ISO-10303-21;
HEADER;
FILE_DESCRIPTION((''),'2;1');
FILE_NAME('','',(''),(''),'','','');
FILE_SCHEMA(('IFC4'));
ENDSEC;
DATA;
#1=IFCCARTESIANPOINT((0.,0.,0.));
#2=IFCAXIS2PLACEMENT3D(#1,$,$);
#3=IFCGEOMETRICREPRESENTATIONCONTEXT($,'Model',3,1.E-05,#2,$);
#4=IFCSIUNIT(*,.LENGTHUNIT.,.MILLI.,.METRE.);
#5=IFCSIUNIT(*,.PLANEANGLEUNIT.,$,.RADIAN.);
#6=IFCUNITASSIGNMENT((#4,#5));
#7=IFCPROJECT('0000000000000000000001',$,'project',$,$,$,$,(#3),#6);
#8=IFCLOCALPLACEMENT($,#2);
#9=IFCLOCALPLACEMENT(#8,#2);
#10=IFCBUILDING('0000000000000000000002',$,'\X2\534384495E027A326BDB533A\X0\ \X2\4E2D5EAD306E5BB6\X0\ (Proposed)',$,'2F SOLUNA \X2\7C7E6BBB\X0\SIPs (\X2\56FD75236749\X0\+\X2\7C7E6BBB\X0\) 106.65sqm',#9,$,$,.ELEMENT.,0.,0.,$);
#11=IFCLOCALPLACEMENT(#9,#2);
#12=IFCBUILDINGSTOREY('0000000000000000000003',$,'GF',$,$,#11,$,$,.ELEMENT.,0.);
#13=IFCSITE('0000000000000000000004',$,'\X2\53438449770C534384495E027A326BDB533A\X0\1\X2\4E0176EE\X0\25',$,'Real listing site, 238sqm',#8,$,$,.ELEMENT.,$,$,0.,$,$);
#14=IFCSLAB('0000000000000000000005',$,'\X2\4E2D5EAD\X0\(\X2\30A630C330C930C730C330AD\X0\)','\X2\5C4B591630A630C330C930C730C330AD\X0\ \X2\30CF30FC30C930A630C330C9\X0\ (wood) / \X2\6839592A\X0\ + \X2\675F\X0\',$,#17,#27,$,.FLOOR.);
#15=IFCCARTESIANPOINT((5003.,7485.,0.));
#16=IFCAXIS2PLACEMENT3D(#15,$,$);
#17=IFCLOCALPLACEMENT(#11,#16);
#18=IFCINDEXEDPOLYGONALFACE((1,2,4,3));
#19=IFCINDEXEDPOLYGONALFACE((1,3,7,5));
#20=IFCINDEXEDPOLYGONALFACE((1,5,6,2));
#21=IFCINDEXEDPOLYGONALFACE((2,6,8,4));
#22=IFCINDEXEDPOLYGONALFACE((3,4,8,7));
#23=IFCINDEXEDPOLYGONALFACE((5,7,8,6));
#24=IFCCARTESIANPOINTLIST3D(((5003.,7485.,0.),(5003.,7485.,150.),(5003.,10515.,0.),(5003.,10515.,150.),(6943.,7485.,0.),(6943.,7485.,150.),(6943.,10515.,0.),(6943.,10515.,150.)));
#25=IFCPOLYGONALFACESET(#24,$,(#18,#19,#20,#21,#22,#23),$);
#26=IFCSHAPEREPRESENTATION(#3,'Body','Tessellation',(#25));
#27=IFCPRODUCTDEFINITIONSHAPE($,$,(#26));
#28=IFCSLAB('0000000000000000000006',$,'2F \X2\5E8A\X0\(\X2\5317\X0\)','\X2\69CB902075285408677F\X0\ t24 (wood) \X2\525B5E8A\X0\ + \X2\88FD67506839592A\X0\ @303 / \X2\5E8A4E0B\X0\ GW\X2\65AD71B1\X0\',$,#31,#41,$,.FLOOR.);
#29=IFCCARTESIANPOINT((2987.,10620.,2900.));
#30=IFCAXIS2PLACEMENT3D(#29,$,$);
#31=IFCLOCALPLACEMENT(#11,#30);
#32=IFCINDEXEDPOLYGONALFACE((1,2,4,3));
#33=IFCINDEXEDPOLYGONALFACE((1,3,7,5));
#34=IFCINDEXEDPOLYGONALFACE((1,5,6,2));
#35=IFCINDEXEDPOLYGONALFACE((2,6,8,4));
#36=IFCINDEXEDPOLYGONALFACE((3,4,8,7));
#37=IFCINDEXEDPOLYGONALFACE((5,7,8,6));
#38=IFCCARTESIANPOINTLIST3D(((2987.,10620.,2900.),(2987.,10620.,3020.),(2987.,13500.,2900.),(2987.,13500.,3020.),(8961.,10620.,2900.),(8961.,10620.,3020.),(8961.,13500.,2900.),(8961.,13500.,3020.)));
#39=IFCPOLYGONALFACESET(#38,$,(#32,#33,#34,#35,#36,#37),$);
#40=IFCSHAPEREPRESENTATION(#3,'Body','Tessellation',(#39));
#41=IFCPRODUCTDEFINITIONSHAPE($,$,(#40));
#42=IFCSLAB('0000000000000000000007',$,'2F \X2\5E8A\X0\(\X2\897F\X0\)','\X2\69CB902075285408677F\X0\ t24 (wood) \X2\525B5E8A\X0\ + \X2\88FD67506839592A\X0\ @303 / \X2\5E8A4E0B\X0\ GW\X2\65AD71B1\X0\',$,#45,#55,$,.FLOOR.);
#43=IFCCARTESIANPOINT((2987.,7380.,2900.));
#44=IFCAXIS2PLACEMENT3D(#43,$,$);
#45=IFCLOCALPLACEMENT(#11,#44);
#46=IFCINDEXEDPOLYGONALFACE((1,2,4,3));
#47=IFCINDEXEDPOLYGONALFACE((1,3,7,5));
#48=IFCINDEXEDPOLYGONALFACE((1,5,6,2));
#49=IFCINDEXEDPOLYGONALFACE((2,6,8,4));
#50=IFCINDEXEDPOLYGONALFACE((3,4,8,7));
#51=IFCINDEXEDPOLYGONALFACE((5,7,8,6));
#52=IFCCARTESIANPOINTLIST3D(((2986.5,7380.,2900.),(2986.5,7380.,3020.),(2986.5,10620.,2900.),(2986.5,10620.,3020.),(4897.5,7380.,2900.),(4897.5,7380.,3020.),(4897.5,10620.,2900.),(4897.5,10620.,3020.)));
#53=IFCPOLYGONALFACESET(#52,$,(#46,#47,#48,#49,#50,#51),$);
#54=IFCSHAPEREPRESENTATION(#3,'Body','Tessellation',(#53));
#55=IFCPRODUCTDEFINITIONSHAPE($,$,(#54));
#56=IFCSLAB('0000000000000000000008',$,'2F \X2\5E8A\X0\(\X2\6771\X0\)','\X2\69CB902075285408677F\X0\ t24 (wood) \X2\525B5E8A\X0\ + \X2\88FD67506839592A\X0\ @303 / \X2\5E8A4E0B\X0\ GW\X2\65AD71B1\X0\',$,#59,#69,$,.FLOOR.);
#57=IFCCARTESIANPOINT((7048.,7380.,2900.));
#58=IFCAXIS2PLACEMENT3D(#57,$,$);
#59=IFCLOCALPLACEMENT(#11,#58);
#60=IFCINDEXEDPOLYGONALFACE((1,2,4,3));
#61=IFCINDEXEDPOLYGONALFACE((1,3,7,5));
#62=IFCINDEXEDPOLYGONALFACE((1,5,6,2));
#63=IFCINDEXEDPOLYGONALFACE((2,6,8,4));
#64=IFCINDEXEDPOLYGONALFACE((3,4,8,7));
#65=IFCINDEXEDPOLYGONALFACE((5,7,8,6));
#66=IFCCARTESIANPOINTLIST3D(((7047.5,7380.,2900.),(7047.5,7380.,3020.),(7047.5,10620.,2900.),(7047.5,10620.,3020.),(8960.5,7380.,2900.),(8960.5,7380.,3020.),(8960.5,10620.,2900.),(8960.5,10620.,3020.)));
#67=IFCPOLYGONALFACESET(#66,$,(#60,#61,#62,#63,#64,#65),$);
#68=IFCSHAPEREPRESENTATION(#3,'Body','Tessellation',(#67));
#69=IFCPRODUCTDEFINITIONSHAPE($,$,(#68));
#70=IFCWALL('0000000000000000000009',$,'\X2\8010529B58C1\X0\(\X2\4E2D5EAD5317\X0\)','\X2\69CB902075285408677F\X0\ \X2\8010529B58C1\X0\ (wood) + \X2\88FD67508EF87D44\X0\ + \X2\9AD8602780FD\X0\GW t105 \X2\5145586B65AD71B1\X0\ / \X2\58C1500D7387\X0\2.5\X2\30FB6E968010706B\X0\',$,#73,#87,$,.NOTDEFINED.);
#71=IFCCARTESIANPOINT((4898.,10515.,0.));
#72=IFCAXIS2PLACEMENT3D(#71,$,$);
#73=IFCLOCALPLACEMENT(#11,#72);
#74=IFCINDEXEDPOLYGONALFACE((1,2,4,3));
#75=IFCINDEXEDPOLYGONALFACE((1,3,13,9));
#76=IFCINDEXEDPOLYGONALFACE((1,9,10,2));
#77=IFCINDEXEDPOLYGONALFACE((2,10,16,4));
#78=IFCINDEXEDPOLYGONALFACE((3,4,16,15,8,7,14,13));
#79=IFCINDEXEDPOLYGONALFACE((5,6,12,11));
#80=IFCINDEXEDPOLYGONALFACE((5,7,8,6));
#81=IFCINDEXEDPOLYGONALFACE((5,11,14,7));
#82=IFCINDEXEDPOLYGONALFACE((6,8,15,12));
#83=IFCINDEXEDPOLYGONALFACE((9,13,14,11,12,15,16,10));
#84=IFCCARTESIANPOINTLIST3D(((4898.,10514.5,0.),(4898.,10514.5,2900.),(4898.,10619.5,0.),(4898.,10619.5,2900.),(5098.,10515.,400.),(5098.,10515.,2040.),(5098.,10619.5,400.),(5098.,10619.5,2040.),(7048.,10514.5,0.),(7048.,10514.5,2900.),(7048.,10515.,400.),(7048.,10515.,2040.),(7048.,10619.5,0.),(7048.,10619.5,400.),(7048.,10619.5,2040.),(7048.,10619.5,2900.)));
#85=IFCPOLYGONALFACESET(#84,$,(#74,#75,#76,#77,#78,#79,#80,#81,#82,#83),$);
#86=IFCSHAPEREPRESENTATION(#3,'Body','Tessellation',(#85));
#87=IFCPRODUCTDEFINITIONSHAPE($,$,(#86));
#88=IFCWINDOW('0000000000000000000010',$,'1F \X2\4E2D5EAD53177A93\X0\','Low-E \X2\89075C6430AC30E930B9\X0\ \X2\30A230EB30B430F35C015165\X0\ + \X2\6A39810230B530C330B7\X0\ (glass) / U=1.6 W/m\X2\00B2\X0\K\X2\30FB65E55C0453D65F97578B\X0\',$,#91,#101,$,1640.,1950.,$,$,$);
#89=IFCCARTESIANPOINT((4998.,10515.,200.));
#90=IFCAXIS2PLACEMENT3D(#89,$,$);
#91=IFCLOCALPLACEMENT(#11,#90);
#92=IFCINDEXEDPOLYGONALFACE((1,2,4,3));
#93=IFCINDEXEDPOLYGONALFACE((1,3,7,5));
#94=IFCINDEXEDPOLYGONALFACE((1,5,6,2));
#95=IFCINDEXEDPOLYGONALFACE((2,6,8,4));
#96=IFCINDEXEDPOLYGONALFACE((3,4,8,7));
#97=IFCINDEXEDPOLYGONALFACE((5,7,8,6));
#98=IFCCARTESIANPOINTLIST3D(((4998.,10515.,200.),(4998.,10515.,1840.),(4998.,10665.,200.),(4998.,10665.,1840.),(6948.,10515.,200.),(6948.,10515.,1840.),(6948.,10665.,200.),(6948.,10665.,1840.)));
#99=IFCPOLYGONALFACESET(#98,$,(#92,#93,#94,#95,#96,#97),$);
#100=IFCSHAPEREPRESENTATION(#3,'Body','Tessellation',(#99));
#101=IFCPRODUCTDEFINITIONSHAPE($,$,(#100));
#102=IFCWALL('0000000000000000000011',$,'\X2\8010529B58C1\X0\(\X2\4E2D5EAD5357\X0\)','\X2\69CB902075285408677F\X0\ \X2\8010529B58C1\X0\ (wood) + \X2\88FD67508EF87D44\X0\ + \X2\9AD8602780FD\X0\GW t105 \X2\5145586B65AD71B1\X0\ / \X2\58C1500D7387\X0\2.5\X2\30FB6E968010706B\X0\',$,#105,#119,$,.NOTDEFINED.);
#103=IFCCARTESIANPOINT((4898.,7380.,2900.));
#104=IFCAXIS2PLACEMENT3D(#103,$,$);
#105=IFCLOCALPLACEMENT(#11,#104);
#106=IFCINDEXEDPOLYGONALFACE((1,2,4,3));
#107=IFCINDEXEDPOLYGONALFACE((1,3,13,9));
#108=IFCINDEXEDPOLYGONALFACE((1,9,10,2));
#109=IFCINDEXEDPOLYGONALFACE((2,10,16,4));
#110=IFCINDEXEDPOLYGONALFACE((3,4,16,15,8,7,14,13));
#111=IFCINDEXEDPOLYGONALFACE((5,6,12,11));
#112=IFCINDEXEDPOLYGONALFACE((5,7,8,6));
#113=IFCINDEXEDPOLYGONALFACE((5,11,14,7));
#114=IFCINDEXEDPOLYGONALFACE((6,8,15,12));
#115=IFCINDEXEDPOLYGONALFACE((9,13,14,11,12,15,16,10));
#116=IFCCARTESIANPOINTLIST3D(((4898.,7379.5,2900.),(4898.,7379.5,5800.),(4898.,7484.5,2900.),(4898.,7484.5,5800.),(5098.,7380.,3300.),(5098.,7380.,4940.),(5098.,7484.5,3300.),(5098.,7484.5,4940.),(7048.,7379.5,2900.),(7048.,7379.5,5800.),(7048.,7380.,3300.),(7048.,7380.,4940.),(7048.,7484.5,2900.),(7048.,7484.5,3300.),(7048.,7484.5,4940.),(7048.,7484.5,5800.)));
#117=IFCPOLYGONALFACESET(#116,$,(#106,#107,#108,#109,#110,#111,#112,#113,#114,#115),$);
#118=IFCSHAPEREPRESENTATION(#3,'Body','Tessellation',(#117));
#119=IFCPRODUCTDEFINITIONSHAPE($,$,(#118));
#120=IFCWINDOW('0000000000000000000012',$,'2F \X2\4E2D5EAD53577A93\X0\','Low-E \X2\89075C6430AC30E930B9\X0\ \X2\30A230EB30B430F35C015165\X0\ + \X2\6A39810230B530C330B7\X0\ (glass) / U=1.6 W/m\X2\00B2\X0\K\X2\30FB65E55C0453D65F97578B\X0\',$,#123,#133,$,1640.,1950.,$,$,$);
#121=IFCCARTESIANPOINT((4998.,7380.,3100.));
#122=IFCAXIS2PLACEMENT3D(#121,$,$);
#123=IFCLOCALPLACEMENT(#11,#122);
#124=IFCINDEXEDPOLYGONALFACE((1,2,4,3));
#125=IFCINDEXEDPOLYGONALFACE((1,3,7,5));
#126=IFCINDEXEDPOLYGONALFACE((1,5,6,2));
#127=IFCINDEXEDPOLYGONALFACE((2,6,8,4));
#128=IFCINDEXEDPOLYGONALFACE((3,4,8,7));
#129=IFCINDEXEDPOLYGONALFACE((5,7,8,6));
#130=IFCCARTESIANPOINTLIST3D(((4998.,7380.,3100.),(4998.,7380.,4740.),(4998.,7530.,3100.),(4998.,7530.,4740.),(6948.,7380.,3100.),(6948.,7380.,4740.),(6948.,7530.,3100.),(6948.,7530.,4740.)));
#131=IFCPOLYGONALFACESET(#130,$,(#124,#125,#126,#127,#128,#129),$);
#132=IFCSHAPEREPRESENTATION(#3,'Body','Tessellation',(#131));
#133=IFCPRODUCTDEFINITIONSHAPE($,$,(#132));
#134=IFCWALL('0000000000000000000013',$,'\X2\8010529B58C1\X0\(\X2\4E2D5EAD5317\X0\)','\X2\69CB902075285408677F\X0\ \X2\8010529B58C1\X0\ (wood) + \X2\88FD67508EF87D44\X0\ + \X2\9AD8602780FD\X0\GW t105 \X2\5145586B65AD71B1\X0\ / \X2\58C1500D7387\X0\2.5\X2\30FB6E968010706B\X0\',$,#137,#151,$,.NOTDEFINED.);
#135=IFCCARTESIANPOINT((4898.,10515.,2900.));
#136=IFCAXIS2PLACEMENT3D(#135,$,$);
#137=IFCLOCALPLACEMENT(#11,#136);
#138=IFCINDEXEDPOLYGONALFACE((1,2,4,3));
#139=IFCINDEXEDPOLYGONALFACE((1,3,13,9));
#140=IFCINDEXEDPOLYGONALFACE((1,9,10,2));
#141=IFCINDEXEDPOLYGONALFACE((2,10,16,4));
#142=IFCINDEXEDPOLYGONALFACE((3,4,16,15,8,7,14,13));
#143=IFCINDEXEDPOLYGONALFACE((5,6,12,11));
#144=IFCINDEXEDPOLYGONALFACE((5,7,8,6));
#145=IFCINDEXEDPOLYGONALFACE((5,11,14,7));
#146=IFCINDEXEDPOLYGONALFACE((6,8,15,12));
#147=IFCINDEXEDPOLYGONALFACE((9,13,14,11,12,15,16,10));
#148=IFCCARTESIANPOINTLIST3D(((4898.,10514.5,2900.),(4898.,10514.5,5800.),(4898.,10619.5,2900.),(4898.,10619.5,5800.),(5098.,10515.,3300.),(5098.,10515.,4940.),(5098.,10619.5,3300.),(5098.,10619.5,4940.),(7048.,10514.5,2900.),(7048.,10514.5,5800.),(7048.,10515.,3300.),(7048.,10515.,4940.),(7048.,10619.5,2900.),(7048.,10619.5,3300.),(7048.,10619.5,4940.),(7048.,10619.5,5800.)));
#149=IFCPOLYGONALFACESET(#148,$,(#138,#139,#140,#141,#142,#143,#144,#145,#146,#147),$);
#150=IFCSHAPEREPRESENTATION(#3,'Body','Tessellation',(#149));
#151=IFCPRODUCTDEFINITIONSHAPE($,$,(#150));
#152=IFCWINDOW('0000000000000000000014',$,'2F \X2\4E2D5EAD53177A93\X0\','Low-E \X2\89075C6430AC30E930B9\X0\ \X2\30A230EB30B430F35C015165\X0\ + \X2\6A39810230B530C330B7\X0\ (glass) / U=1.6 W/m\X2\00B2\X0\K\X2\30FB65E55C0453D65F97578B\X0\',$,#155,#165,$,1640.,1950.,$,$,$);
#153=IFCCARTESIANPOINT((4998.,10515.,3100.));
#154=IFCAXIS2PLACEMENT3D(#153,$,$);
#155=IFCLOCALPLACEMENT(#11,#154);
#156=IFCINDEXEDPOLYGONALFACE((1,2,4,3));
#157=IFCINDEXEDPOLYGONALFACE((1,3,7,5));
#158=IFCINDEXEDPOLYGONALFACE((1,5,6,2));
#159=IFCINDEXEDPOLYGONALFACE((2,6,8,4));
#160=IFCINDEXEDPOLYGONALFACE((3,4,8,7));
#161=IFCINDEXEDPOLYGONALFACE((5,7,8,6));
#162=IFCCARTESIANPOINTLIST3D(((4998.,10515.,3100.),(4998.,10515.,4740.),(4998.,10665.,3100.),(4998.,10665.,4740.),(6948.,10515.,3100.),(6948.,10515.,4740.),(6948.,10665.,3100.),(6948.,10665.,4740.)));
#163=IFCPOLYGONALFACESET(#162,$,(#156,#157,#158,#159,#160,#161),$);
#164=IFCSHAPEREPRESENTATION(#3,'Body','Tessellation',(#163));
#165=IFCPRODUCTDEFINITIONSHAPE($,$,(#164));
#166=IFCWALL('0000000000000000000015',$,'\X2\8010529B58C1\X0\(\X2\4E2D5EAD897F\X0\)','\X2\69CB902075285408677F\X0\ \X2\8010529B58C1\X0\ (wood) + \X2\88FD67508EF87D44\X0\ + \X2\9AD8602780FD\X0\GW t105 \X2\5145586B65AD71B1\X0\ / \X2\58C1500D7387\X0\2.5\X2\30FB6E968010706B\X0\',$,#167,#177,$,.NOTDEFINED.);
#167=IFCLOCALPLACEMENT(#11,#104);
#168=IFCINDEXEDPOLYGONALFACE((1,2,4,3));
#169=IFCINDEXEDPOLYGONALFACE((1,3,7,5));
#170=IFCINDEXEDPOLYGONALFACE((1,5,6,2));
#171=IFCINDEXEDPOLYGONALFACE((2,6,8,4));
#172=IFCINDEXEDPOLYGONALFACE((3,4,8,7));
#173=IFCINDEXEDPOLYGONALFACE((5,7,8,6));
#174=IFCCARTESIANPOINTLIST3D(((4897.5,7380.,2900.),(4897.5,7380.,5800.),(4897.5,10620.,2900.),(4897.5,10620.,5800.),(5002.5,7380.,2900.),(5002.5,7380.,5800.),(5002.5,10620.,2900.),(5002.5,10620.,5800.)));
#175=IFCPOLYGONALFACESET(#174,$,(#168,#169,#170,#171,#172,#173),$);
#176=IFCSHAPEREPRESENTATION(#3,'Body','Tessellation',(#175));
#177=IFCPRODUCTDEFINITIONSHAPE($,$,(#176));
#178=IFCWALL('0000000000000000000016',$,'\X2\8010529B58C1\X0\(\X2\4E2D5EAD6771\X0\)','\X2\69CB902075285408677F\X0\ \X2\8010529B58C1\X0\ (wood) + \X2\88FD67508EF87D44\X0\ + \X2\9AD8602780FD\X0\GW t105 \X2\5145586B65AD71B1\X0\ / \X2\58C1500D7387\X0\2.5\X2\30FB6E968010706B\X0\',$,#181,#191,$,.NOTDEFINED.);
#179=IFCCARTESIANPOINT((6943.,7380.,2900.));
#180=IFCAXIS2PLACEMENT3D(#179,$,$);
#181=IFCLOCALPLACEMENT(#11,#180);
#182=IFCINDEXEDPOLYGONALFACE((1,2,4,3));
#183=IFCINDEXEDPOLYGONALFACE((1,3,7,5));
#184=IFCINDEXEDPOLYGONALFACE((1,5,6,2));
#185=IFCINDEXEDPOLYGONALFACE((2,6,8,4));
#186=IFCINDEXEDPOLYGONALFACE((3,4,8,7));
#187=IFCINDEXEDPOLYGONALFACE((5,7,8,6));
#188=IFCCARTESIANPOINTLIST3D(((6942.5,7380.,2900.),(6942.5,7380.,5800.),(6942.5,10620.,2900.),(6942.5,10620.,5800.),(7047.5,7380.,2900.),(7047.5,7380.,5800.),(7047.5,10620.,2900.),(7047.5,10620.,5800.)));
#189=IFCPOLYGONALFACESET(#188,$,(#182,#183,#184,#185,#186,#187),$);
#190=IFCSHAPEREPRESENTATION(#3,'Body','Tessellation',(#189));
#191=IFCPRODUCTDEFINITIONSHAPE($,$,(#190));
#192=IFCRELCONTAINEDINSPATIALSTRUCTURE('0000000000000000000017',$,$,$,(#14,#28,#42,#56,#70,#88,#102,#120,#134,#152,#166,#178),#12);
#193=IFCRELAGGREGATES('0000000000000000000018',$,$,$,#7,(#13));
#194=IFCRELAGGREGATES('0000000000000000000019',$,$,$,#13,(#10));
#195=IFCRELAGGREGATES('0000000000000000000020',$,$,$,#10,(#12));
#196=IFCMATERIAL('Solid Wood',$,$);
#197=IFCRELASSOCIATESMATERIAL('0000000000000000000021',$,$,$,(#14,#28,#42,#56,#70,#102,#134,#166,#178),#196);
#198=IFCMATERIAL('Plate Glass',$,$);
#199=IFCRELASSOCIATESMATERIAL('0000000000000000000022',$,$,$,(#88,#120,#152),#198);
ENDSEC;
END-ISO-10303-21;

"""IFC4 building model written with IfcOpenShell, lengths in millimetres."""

from ifc_helpers import new_model, si_unit, frame, frame_2d, origin, place, context, project, spatial, rectangle, extrude, material, element, fill, save


model = new_model("IFC4")

# Units and contexts
model_context = context("Model", 3, precision=1e-05, world=origin())
ifc_project = project(units=[si_unit("LENGTHUNIT", "METRE", prefix="MILLI"), si_unit("PLANEANGLEUNIT", "RADIAN")], contexts=[model_context])

# Site, building, storey
site_placement = place(None, origin())
site = spatial("IfcSite", under=ifc_project, at=site_placement, Name="千葉県千葉市稲毛区1丁目25", ObjectType="Real listing site, 238sqm", CompositionType="ELEMENT", RefElevation=0.0)
building_placement = place(site_placement, origin())
building = spatial("IfcBuilding", under=site, at=building_placement, Name="千葉市稲毛区 中庭の家 (Proposed)", ObjectType="2F SOLUNA 籾殻SIPs (国産杉+籾殻) 106.65sqm", CompositionType="ELEMENT", ElevationOfRefHeight=0.0, ElevationOfTerrain=0.0)
storey_placement = place(building_placement, origin())
storey = spatial("IfcBuildingStorey", under=building, at=storey_placement, Name="GF", CompositionType="ELEMENT", Elevation=0.0)

# Slabs
ifc_material_1 = material(Name="Solid Wood")
slab_1_placement = place(storey_placement, frame((5003.0, 7485.0, 0.0)))
element("IfcSlab", 1, at=slab_1_placement, inside=storey, material=ifc_material_1, Name="中庭(ウッドデッキ)", Description="屋外ウッドデッキ ハードウッド (wood) / 根太 + 束", PredefinedType="FLOOR", context=model_context, shape_type="SweptSolid", body=[
    extrude(rectangle(XDim=1940.0, YDim=3030.0, at=frame_2d((970.0, 1515.0))), frame((5003.0, 7485.0, 0.0)), (0.0, 0.0, 1.0), 150.0),
])
slab_2_placement = place(storey_placement, frame((2987.0, 10620.0, 2900.0)))
element("IfcSlab", 2, at=slab_2_placement, inside=storey, material=ifc_material_1, Name="2F 床(北)", Description="構造用合板 t24 (wood) 剛床 + 製材根太 @303 / 床下 GW断熱", PredefinedType="FLOOR", context=model_context, shape_type="SweptSolid", body=[
    extrude(rectangle(XDim=5974.0, YDim=2880.0, at=frame_2d((2987.0, 1440.0))), frame((2987.0, 10620.0, 2900.0)), (0.0, 0.0, 1.0), 120.0),
])
slab_3_placement = place(storey_placement, frame((2987.0, 7380.0, 2900.0)))
element("IfcSlab", 3, at=slab_3_placement, inside=storey, material=ifc_material_1, Name="2F 床(西)", Description="構造用合板 t24 (wood) 剛床 + 製材根太 @303 / 床下 GW断熱", PredefinedType="FLOOR", context=model_context, shape_type="SweptSolid", body=[
    extrude(rectangle(XDim=1911.0, YDim=3240.0, at=frame_2d((955.0, 1620.0))), frame((2987.0, 7380.0, 2900.0)), (0.0, 0.0, 1.0), 120.0),
])
slab_4_placement = place(storey_placement, frame((7048.0, 7380.0, 2900.0)))
element("IfcSlab", 4, at=slab_4_placement, inside=storey, material=ifc_material_1, Name="2F 床(東)", Description="構造用合板 t24 (wood) 剛床 + 製材根太 @303 / 床下 GW断熱", PredefinedType="FLOOR", context=model_context, shape_type="SweptSolid", body=[
    extrude(rectangle(XDim=1913.0, YDim=3240.0, at=frame_2d((956.0, 1620.0))), frame((7048.0, 7380.0, 2900.0)), (0.0, 0.0, 1.0), 120.0),
])

# Wall, opening, window
wall_1_placement = place(storey_placement, frame((4898.0, 10515.0, 0.0)))
wall_1 = element("IfcWall", 5, at=wall_1_placement, inside=storey, material=ifc_material_1, Name="耐力壁(中庭北)", Description="構造用合板 耐力壁 (wood) + 製材軸組 + 高性能GW t105 充填断熱 / 壁倍率2.5・準耐火", PredefinedType="NOTDEFINED", context=model_context, shape_type="SweptSolid", body=[
    extrude(rectangle(XDim=2150.0, YDim=105.0, at=frame_2d((1075.0, 52.0))), frame((4898.0, 10515.0, 0.0)), (0.0, 0.0, 1.0), 2900.0),
])
opening_1_placement = place(storey_placement, frame((4998.0, 10515.0, 200.0)))
opening_1 = element("IfcOpeningElement", 6, at=opening_1_placement, cuts=wall_1, PredefinedType="NOTDEFINED", context=model_context, shape_type="SweptSolid", body=[
    extrude(rectangle(XDim=1950.0, YDim=150.0, at=frame_2d((975.0, 75.0))), frame((4998.0, 10515.0, 200.0)), (0.0, 0.0, 1.0), 1640.0),
])
ifc_material_2 = material(Name="Plate Glass")
window_1_placement = place(storey_placement, frame((4998.0, 10515.0, 200.0)))
window_1 = element("IfcWindow", 7, at=window_1_placement, inside=storey, material=ifc_material_2, Name="1F 中庭北窓", Description="Low-E 複層ガラス アルゴン封入 + 樹脂サッシ (glass) / U=1.6 W/m²K・日射取得型", OverallHeight=1640.0, OverallWidth=1950.0, context=model_context, shape_type="SweptSolid", body=[
    extrude(rectangle(XDim=1950.0, YDim=150.0, at=frame_2d((975.0, 75.0))), frame((4998.0, 10515.0, 200.0)), (0.0, 0.0, 1.0), 1640.0),
])
fill(opening_1, window_1)

# Walls, openings, windows
wall_2_placement = place(storey_placement, frame((4898.0, 7380.0, 2900.0)))
wall_2 = element("IfcWall", 8, at=wall_2_placement, inside=storey, material=ifc_material_1, Name="耐力壁(中庭南)", Description="構造用合板 耐力壁 (wood) + 製材軸組 + 高性能GW t105 充填断熱 / 壁倍率2.5・準耐火", PredefinedType="NOTDEFINED", context=model_context, shape_type="SweptSolid", body=[
    extrude(rectangle(XDim=2150.0, YDim=105.0, at=frame_2d((1075.0, 52.0))), frame((4898.0, 7380.0, 2900.0)), (0.0, 0.0, 1.0), 2900.0),
])
opening_2_placement = place(storey_placement, frame((4998.0, 7380.0, 3100.0)))
opening_2 = element("IfcOpeningElement", 9, at=opening_2_placement, cuts=wall_2, PredefinedType="NOTDEFINED", context=model_context, shape_type="SweptSolid", body=[
    extrude(rectangle(XDim=1950.0, YDim=150.0, at=frame_2d((975.0, 75.0))), frame((4998.0, 7380.0, 3100.0)), (0.0, 0.0, 1.0), 1640.0),
])
window_2_placement = place(storey_placement, frame((4998.0, 7380.0, 3100.0)))
window_2 = element("IfcWindow", 10, at=window_2_placement, inside=storey, material=ifc_material_2, Name="2F 中庭南窓", Description="Low-E 複層ガラス アルゴン封入 + 樹脂サッシ (glass) / U=1.6 W/m²K・日射取得型", OverallHeight=1640.0, OverallWidth=1950.0, context=model_context, shape_type="SweptSolid", body=[
    extrude(rectangle(XDim=1950.0, YDim=150.0, at=frame_2d((975.0, 75.0))), frame((4998.0, 7380.0, 3100.0)), (0.0, 0.0, 1.0), 1640.0),
])
fill(opening_2, window_2)
wall_3_placement = place(storey_placement, frame((4898.0, 10515.0, 2900.0)))
wall_3 = element("IfcWall", 11, at=wall_3_placement, inside=storey, material=ifc_material_1, Name="耐力壁(中庭北)", Description="構造用合板 耐力壁 (wood) + 製材軸組 + 高性能GW t105 充填断熱 / 壁倍率2.5・準耐火", PredefinedType="NOTDEFINED", context=model_context, shape_type="SweptSolid", body=[
    extrude(rectangle(XDim=2150.0, YDim=105.0, at=frame_2d((1075.0, 52.0))), frame((4898.0, 10515.0, 2900.0)), (0.0, 0.0, 1.0), 2900.0),
])
opening_3_placement = place(storey_placement, frame((4998.0, 10515.0, 3100.0)))
opening_3 = element("IfcOpeningElement", 12, at=opening_3_placement, cuts=wall_3, PredefinedType="NOTDEFINED", context=model_context, shape_type="SweptSolid", body=[
    extrude(rectangle(XDim=1950.0, YDim=150.0, at=frame_2d((975.0, 75.0))), frame((4998.0, 10515.0, 3100.0)), (0.0, 0.0, 1.0), 1640.0),
])
window_3_placement = place(storey_placement, frame((4998.0, 10515.0, 3100.0)))
window_3 = element("IfcWindow", 13, at=window_3_placement, inside=storey, material=ifc_material_2, Name="2F 中庭北窓", Description="Low-E 複層ガラス アルゴン封入 + 樹脂サッシ (glass) / U=1.6 W/m²K・日射取得型", OverallHeight=1640.0, OverallWidth=1950.0, context=model_context, shape_type="SweptSolid", body=[
    extrude(rectangle(XDim=1950.0, YDim=150.0, at=frame_2d((975.0, 75.0))), frame((4998.0, 10515.0, 3100.0)), (0.0, 0.0, 1.0), 1640.0),
])
fill(opening_3, window_3)

# Walls
wall_4_placement = place(storey_placement, frame((4898.0, 7380.0, 2900.0)))
element("IfcWall", 14, at=wall_4_placement, inside=storey, material=ifc_material_1, Name="耐力壁(中庭西)", Description="構造用合板 耐力壁 (wood) + 製材軸組 + 高性能GW t105 充填断熱 / 壁倍率2.5・準耐火", PredefinedType="NOTDEFINED", context=model_context, shape_type="SweptSolid", body=[
    extrude(rectangle(XDim=105.0, YDim=3240.0, at=frame_2d((52.0, 1620.0))), frame((4898.0, 7380.0, 2900.0)), (0.0, 0.0, 1.0), 2900.0),
])
wall_5_placement = place(storey_placement, frame((6943.0, 7380.0, 2900.0)))
element("IfcWall", 15, at=wall_5_placement, inside=storey, material=ifc_material_1, Name="耐力壁(中庭東)", Description="構造用合板 耐力壁 (wood) + 製材軸組 + 高性能GW t105 充填断熱 / 壁倍率2.5・準耐火", PredefinedType="NOTDEFINED", context=model_context, shape_type="SweptSolid", body=[
    extrude(rectangle(XDim=105.0, YDim=3240.0, at=frame_2d((52.0, 1620.0))), frame((6943.0, 7380.0, 2900.0)), (0.0, 0.0, 1.0), 2900.0),
])

save(model, "model.ifc")
